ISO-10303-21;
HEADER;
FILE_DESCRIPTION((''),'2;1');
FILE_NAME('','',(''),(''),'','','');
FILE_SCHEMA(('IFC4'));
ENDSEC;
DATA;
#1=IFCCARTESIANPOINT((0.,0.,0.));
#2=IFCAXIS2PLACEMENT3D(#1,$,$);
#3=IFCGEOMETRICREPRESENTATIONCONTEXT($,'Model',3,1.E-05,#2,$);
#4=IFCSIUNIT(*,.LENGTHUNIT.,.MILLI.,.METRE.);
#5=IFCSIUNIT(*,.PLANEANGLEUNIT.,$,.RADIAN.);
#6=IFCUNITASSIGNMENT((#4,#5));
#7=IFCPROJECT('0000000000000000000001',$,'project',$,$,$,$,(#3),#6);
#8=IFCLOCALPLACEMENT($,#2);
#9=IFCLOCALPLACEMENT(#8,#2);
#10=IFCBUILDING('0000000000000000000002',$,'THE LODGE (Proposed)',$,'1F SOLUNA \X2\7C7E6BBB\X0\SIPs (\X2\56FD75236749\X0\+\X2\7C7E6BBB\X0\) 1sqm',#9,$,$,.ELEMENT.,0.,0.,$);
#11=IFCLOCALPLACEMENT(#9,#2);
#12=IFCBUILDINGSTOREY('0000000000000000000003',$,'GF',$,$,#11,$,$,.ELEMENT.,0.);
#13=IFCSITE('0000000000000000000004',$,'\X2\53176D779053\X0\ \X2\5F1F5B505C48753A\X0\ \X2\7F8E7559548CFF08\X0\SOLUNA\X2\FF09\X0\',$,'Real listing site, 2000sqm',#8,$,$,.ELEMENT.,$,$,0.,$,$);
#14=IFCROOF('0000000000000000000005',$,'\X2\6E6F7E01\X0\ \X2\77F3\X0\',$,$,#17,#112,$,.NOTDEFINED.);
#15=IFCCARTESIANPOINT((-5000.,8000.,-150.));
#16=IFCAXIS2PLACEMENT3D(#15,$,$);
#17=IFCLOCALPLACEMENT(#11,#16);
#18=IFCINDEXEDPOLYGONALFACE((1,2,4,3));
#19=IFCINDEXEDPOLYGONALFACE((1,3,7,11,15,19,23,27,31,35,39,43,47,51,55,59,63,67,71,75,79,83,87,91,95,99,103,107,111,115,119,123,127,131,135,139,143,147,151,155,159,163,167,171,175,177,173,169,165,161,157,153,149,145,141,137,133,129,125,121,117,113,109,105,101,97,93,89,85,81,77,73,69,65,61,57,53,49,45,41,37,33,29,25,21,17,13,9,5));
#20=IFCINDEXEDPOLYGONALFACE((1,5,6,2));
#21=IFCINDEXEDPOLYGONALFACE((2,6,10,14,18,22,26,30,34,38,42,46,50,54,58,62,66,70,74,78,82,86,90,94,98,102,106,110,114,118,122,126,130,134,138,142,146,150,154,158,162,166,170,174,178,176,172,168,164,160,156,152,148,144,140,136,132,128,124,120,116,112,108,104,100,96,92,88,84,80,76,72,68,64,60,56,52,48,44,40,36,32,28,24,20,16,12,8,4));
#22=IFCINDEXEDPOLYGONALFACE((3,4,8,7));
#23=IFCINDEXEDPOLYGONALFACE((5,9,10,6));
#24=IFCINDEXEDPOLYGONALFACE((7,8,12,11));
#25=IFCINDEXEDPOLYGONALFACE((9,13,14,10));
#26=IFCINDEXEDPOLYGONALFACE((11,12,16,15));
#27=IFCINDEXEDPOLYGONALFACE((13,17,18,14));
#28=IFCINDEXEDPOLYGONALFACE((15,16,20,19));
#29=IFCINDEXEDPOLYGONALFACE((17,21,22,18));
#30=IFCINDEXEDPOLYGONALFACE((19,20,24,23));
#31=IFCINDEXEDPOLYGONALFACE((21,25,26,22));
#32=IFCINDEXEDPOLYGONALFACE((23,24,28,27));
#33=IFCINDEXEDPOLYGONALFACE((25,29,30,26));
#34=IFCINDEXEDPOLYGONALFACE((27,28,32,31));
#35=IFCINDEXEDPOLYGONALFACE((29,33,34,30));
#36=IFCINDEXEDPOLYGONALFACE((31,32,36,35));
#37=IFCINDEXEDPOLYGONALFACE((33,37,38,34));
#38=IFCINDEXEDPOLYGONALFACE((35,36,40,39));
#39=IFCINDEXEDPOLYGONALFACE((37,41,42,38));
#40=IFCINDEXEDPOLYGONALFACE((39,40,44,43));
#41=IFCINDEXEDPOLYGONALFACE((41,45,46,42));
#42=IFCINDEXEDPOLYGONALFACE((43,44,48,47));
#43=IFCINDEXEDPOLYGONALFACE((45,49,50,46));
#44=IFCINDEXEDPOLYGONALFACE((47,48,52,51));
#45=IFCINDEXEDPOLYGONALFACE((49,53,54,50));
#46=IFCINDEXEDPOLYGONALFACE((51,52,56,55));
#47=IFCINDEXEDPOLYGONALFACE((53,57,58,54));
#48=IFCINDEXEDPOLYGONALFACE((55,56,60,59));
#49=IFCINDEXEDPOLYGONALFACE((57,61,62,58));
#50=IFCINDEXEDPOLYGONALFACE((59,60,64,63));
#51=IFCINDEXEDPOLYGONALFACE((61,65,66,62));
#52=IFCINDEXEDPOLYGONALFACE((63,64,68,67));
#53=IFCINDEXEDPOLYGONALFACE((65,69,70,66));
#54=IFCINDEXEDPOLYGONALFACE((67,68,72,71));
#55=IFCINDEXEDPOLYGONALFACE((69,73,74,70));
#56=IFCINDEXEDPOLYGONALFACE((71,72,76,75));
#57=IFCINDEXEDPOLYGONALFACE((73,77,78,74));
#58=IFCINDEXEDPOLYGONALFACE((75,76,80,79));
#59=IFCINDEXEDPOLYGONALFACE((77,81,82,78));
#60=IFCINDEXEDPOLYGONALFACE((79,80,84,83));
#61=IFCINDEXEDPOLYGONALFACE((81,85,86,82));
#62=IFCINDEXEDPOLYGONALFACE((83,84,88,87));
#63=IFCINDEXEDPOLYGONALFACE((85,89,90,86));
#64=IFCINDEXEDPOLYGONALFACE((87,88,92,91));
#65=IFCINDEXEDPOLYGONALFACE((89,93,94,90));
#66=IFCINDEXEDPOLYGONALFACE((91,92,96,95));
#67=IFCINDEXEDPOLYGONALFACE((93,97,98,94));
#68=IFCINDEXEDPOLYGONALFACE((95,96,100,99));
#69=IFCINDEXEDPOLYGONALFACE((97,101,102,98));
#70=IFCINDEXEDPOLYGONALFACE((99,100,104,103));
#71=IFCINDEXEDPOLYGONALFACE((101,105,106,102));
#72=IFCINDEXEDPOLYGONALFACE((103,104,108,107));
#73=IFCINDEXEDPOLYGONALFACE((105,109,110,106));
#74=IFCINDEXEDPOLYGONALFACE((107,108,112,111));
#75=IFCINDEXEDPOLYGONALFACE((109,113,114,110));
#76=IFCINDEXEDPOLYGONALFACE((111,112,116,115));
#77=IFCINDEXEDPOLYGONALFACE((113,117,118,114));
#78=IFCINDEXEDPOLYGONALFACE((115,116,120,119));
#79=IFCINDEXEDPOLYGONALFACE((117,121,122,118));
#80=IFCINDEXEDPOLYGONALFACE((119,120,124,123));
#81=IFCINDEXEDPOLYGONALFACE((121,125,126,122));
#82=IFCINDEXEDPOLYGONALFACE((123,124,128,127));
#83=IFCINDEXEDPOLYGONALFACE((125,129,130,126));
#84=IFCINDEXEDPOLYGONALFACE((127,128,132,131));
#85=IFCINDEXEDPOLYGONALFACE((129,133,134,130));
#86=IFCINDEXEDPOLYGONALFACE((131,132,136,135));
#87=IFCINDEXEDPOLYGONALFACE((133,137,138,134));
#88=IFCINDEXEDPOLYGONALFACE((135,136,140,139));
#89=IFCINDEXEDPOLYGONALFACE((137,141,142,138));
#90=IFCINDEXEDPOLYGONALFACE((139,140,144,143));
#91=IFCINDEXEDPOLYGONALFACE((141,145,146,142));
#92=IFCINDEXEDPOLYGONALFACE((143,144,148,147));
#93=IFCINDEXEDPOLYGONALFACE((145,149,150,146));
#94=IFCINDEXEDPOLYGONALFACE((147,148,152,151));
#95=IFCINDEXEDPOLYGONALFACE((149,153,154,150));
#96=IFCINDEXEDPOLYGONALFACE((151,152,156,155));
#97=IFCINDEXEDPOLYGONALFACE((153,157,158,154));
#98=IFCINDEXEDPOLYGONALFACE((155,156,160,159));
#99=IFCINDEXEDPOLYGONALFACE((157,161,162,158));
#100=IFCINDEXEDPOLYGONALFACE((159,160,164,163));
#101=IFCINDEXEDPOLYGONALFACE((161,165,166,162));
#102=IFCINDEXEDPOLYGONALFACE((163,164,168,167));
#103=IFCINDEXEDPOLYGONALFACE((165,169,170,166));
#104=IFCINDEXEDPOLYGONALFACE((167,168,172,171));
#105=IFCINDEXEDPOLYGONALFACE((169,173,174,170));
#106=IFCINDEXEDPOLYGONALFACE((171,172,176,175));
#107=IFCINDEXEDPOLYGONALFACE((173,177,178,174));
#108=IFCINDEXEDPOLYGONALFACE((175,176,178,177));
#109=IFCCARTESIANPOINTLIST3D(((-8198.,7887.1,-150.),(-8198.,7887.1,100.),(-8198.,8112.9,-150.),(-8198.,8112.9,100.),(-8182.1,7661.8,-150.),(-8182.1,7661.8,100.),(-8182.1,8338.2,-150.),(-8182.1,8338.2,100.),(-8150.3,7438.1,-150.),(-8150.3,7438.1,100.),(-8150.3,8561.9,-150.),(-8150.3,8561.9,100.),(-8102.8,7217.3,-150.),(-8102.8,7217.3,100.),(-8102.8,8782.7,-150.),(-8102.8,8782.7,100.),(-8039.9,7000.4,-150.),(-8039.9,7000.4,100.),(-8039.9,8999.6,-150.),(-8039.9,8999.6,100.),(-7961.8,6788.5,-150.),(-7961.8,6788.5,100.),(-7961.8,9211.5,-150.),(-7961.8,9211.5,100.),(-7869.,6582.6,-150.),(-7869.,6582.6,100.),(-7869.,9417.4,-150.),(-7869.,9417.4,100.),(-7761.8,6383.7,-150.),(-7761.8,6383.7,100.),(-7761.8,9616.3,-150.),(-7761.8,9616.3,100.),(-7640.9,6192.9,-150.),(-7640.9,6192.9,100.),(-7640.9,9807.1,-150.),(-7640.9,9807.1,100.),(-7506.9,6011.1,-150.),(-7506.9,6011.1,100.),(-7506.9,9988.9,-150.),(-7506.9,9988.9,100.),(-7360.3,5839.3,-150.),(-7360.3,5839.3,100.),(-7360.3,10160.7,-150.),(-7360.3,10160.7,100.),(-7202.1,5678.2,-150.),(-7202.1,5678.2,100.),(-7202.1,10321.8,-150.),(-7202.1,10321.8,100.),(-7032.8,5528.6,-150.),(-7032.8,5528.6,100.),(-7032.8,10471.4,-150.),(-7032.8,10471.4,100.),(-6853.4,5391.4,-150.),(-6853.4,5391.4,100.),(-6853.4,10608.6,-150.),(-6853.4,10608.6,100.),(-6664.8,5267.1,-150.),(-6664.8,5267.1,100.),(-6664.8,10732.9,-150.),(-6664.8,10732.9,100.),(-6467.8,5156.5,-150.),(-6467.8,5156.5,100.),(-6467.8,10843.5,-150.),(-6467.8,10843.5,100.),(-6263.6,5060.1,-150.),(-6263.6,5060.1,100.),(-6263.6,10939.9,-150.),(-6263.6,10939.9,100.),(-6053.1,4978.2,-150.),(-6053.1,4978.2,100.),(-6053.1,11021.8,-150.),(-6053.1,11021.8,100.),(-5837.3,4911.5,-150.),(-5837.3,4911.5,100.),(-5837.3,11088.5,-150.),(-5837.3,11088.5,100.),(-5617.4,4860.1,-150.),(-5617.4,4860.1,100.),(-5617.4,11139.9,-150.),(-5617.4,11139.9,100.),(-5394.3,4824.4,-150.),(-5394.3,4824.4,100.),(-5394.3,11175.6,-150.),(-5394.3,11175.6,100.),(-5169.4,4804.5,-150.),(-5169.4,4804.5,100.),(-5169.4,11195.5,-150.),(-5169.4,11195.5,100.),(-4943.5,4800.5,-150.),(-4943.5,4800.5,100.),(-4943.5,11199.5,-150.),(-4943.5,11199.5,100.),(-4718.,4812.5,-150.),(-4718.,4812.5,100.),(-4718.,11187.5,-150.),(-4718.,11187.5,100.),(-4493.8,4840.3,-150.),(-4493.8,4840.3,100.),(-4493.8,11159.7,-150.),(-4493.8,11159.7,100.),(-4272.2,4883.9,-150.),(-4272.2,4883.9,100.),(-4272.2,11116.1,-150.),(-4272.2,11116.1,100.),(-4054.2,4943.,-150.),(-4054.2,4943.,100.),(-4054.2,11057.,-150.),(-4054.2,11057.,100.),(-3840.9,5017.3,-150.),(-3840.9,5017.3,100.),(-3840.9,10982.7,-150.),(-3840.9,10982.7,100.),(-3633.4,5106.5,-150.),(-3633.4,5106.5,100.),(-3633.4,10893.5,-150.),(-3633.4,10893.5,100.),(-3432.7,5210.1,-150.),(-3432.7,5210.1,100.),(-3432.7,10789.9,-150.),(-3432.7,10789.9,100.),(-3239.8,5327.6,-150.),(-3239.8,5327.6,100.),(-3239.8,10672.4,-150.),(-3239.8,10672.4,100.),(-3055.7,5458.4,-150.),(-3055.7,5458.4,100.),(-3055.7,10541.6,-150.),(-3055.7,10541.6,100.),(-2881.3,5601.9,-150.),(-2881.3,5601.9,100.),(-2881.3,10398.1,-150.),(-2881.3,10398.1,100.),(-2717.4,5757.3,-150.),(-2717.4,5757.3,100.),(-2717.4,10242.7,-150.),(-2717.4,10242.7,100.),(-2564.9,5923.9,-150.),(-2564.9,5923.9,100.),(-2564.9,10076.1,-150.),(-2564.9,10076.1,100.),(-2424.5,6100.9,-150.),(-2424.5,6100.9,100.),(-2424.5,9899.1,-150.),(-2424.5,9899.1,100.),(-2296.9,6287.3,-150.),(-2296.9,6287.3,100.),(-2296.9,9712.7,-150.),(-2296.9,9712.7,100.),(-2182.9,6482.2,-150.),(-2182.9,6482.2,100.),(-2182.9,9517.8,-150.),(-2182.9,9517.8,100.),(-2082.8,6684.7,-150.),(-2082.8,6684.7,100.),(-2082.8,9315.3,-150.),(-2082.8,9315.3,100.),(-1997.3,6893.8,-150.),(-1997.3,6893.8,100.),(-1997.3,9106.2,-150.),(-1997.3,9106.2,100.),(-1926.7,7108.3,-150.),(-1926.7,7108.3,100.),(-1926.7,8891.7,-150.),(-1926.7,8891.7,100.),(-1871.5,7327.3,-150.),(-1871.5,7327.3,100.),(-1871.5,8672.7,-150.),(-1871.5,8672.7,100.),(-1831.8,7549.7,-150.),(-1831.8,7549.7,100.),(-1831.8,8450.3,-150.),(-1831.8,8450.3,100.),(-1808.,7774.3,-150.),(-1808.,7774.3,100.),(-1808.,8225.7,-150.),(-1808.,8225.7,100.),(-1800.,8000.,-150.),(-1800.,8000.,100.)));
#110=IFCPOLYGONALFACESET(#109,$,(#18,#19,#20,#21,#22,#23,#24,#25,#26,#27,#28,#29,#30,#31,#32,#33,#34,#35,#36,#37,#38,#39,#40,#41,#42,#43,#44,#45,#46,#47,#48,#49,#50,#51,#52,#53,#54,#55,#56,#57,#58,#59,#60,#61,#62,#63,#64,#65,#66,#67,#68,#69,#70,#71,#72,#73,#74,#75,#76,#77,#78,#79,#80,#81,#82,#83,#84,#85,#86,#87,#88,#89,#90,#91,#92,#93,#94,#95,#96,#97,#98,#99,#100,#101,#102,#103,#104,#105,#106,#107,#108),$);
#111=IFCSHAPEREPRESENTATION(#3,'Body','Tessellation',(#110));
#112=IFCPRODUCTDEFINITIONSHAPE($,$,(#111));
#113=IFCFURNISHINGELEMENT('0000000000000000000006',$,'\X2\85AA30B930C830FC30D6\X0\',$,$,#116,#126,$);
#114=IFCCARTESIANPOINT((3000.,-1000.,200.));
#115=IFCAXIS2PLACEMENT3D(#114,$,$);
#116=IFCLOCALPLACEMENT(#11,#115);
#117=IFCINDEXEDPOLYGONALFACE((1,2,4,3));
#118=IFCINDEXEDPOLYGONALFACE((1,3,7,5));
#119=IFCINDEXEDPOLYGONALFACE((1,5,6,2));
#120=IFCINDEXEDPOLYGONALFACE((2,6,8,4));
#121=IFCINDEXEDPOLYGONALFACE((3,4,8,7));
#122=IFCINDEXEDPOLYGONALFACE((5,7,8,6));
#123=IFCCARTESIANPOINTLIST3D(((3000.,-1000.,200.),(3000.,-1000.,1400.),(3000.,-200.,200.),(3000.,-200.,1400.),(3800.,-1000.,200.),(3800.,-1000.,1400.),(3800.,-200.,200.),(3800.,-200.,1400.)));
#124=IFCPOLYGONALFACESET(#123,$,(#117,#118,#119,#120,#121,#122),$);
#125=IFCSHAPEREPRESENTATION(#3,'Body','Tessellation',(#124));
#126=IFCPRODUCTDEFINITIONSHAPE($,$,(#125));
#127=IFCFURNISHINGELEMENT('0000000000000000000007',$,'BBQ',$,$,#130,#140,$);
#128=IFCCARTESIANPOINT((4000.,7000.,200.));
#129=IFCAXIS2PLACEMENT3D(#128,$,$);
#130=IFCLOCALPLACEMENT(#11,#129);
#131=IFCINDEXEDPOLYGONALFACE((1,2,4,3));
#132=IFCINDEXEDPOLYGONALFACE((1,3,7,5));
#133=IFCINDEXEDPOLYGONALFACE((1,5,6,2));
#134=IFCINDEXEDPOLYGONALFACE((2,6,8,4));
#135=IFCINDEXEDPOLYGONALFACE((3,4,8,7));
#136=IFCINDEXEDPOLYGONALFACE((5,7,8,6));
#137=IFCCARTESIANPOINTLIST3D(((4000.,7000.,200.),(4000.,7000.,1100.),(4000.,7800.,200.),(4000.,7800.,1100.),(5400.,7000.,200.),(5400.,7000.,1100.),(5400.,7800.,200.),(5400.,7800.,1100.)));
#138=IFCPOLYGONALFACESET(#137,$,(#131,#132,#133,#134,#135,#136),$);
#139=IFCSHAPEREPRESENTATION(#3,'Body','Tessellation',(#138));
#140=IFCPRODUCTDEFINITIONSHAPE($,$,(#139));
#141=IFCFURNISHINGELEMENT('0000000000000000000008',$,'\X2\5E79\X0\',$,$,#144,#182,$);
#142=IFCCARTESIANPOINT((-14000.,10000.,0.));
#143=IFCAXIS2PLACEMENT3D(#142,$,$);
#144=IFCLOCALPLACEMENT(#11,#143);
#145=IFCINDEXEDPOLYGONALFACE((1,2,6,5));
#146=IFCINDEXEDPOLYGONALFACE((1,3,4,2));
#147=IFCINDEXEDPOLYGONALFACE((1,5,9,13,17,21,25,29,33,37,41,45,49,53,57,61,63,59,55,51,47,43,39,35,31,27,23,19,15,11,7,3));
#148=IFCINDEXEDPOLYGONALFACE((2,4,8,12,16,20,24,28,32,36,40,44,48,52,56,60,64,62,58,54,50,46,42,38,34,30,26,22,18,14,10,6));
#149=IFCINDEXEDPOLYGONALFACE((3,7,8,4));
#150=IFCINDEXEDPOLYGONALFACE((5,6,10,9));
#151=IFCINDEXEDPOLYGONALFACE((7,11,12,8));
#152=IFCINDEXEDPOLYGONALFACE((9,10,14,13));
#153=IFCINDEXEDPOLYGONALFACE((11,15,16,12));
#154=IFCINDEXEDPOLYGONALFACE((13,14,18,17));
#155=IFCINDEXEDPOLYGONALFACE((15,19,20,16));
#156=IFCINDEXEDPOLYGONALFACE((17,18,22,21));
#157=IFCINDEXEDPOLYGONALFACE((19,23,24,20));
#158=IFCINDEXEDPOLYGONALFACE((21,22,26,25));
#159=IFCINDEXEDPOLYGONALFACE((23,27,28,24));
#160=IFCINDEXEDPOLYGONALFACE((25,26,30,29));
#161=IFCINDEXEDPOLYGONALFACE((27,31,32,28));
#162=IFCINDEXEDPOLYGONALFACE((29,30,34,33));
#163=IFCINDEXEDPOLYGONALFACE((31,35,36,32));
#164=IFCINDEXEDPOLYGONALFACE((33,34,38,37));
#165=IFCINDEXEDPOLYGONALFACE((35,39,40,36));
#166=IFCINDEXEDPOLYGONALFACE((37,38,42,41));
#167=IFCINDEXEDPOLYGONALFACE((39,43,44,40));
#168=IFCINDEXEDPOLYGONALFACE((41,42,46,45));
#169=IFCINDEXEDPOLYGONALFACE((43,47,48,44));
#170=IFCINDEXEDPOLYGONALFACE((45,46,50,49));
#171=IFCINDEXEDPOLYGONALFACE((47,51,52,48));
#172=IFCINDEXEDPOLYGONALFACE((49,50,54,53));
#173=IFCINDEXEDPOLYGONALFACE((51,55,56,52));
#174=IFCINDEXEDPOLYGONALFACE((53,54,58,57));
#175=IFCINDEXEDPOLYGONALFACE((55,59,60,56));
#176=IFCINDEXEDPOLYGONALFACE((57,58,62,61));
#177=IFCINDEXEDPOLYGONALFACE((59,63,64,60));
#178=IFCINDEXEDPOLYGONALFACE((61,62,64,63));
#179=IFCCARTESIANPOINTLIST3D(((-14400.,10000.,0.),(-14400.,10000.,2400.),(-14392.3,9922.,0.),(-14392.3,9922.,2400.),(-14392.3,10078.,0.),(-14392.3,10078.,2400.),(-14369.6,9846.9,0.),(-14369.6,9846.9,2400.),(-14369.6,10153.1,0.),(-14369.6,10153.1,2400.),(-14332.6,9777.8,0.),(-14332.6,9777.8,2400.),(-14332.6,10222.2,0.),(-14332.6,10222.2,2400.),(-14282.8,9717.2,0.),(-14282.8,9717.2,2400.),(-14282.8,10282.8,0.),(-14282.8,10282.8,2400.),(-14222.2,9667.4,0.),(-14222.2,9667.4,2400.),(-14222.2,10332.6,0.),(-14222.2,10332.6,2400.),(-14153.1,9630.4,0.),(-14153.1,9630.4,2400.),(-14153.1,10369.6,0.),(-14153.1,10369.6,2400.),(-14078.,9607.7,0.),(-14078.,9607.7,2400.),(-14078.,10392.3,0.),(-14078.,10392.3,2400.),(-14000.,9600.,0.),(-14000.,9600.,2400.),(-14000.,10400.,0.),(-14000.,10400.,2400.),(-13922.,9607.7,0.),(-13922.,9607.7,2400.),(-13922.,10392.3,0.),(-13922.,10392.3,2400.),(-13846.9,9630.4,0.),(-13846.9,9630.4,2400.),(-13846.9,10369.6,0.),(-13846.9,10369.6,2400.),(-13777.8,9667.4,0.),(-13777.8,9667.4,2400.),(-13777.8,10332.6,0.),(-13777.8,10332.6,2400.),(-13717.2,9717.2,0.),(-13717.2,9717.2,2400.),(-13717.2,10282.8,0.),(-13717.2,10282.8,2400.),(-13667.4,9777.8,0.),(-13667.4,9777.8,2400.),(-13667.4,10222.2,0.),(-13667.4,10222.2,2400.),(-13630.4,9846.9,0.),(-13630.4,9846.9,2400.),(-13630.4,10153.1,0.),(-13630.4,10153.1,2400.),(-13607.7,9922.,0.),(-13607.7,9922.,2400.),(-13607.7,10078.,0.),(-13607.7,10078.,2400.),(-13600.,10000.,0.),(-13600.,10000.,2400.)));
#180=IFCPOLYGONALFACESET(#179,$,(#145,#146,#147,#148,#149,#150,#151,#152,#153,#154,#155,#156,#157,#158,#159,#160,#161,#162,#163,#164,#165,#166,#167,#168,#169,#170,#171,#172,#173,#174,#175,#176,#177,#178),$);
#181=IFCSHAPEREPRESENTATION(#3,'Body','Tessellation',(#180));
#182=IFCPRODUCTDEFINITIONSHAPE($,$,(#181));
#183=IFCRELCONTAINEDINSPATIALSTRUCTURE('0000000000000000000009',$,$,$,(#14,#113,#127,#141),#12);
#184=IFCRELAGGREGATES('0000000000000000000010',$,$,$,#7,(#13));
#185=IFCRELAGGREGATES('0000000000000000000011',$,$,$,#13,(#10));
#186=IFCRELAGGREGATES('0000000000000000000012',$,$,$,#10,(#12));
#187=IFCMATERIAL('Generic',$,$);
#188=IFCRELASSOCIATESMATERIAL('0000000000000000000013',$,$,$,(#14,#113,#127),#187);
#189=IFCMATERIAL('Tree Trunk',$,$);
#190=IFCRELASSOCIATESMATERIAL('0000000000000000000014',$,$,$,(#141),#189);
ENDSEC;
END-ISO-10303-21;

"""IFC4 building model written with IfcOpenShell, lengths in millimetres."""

from ifc_helpers import new_model, si_unit, frame, frame_2d, origin, origin_2d, place, context, project, spatial, rectangle, circle, extrude, material, element, save


model = new_model("IFC4")

# Units and contexts
model_context = context("Model", 3, precision=1e-05, world=origin())
ifc_project = project(units=[si_unit("LENGTHUNIT", "METRE", prefix="MILLI"), si_unit("PLANEANGLEUNIT", "RADIAN")], contexts=[model_context])

# Site, building, storey
site_placement = place(None, origin())
site = spatial("IfcSite", under=ifc_project, at=site_placement, Name="北海道 弟子屈町 美留和（SOLUNA）", ObjectType="Real listing site, 2000sqm", CompositionType="ELEMENT", RefElevation=0.0)
building_placement = place(site_placement, origin())
building = spatial("IfcBuilding", under=site, at=building_placement, Name="THE LODGE (Proposed)", ObjectType="1F SOLUNA 籾殻SIPs (国産杉+籾殻) 1sqm", CompositionType="ELEMENT", ElevationOfRefHeight=0.0, ElevationOfTerrain=0.0)
storey_placement = place(building_placement, origin())
storey = spatial("IfcBuildingStorey", under=building, at=storey_placement, Name="GF", CompositionType="ELEMENT", Elevation=0.0)

# Shared definitions
ifc_material_1 = material(Name="Generic")

# Roof
roof_1_placement = place(storey_placement, frame((-5000.0, 8000.0, -150.0)))
element("IfcRoof", 1, at=roof_1_placement, inside=storey, material=ifc_material_1, Name="湯縁 石", PredefinedType="NOTDEFINED", context=model_context, shape_type="SweptSolid", body=[
    extrude(circle(Radius=3200.0, at=origin_2d()), frame((-5000.0, 8000.0, -150.0)), (0.0, 0.0, 1.0), 250.0),
])

# Furnishing elements
furnishing_1_placement = place(storey_placement, frame((3000.0, -1000.0, 200.0)))
element("IfcFurnishingElement", 2, at=furnishing_1_placement, inside=storey, material=ifc_material_1, Name="薪ストーブ", context=model_context, shape_type="SweptSolid", body=[
    extrude(rectangle(XDim=800.0, YDim=800.0, at=frame_2d((400.0, 400.0))), frame((3000.0, -1000.0, 200.0)), (0.0, 0.0, 1.0), 1200.0),
])
furnishing_2_placement = place(storey_placement, frame((4000.0, 7000.0, 200.0)))
element("IfcFurnishingElement", 3, at=furnishing_2_placement, inside=storey, material=ifc_material_1, Name="BBQ", context=model_context, shape_type="SweptSolid", body=[
    extrude(rectangle(XDim=1400.0, YDim=800.0, at=frame_2d((700.0, 400.0))), frame((4000.0, 7000.0, 200.0)), (0.0, 0.0, 1.0), 900.0),
])
ifc_material_2 = material(Name="Tree Trunk")
furnishing_3_placement = place(storey_placement, frame((-14000.0, 10000.0, 0.0)))
element("IfcFurnishingElement", 4, at=furnishing_3_placement, inside=storey, material=ifc_material_2, Name="幹", context=model_context, shape_type="SweptSolid", body=[
    extrude(circle(Radius=400.0, at=origin_2d()), frame((-14000.0, 10000.0, 0.0)), (0.0, 0.0, 1.0), 2400.0),
])

save(model, "model.ifc")
